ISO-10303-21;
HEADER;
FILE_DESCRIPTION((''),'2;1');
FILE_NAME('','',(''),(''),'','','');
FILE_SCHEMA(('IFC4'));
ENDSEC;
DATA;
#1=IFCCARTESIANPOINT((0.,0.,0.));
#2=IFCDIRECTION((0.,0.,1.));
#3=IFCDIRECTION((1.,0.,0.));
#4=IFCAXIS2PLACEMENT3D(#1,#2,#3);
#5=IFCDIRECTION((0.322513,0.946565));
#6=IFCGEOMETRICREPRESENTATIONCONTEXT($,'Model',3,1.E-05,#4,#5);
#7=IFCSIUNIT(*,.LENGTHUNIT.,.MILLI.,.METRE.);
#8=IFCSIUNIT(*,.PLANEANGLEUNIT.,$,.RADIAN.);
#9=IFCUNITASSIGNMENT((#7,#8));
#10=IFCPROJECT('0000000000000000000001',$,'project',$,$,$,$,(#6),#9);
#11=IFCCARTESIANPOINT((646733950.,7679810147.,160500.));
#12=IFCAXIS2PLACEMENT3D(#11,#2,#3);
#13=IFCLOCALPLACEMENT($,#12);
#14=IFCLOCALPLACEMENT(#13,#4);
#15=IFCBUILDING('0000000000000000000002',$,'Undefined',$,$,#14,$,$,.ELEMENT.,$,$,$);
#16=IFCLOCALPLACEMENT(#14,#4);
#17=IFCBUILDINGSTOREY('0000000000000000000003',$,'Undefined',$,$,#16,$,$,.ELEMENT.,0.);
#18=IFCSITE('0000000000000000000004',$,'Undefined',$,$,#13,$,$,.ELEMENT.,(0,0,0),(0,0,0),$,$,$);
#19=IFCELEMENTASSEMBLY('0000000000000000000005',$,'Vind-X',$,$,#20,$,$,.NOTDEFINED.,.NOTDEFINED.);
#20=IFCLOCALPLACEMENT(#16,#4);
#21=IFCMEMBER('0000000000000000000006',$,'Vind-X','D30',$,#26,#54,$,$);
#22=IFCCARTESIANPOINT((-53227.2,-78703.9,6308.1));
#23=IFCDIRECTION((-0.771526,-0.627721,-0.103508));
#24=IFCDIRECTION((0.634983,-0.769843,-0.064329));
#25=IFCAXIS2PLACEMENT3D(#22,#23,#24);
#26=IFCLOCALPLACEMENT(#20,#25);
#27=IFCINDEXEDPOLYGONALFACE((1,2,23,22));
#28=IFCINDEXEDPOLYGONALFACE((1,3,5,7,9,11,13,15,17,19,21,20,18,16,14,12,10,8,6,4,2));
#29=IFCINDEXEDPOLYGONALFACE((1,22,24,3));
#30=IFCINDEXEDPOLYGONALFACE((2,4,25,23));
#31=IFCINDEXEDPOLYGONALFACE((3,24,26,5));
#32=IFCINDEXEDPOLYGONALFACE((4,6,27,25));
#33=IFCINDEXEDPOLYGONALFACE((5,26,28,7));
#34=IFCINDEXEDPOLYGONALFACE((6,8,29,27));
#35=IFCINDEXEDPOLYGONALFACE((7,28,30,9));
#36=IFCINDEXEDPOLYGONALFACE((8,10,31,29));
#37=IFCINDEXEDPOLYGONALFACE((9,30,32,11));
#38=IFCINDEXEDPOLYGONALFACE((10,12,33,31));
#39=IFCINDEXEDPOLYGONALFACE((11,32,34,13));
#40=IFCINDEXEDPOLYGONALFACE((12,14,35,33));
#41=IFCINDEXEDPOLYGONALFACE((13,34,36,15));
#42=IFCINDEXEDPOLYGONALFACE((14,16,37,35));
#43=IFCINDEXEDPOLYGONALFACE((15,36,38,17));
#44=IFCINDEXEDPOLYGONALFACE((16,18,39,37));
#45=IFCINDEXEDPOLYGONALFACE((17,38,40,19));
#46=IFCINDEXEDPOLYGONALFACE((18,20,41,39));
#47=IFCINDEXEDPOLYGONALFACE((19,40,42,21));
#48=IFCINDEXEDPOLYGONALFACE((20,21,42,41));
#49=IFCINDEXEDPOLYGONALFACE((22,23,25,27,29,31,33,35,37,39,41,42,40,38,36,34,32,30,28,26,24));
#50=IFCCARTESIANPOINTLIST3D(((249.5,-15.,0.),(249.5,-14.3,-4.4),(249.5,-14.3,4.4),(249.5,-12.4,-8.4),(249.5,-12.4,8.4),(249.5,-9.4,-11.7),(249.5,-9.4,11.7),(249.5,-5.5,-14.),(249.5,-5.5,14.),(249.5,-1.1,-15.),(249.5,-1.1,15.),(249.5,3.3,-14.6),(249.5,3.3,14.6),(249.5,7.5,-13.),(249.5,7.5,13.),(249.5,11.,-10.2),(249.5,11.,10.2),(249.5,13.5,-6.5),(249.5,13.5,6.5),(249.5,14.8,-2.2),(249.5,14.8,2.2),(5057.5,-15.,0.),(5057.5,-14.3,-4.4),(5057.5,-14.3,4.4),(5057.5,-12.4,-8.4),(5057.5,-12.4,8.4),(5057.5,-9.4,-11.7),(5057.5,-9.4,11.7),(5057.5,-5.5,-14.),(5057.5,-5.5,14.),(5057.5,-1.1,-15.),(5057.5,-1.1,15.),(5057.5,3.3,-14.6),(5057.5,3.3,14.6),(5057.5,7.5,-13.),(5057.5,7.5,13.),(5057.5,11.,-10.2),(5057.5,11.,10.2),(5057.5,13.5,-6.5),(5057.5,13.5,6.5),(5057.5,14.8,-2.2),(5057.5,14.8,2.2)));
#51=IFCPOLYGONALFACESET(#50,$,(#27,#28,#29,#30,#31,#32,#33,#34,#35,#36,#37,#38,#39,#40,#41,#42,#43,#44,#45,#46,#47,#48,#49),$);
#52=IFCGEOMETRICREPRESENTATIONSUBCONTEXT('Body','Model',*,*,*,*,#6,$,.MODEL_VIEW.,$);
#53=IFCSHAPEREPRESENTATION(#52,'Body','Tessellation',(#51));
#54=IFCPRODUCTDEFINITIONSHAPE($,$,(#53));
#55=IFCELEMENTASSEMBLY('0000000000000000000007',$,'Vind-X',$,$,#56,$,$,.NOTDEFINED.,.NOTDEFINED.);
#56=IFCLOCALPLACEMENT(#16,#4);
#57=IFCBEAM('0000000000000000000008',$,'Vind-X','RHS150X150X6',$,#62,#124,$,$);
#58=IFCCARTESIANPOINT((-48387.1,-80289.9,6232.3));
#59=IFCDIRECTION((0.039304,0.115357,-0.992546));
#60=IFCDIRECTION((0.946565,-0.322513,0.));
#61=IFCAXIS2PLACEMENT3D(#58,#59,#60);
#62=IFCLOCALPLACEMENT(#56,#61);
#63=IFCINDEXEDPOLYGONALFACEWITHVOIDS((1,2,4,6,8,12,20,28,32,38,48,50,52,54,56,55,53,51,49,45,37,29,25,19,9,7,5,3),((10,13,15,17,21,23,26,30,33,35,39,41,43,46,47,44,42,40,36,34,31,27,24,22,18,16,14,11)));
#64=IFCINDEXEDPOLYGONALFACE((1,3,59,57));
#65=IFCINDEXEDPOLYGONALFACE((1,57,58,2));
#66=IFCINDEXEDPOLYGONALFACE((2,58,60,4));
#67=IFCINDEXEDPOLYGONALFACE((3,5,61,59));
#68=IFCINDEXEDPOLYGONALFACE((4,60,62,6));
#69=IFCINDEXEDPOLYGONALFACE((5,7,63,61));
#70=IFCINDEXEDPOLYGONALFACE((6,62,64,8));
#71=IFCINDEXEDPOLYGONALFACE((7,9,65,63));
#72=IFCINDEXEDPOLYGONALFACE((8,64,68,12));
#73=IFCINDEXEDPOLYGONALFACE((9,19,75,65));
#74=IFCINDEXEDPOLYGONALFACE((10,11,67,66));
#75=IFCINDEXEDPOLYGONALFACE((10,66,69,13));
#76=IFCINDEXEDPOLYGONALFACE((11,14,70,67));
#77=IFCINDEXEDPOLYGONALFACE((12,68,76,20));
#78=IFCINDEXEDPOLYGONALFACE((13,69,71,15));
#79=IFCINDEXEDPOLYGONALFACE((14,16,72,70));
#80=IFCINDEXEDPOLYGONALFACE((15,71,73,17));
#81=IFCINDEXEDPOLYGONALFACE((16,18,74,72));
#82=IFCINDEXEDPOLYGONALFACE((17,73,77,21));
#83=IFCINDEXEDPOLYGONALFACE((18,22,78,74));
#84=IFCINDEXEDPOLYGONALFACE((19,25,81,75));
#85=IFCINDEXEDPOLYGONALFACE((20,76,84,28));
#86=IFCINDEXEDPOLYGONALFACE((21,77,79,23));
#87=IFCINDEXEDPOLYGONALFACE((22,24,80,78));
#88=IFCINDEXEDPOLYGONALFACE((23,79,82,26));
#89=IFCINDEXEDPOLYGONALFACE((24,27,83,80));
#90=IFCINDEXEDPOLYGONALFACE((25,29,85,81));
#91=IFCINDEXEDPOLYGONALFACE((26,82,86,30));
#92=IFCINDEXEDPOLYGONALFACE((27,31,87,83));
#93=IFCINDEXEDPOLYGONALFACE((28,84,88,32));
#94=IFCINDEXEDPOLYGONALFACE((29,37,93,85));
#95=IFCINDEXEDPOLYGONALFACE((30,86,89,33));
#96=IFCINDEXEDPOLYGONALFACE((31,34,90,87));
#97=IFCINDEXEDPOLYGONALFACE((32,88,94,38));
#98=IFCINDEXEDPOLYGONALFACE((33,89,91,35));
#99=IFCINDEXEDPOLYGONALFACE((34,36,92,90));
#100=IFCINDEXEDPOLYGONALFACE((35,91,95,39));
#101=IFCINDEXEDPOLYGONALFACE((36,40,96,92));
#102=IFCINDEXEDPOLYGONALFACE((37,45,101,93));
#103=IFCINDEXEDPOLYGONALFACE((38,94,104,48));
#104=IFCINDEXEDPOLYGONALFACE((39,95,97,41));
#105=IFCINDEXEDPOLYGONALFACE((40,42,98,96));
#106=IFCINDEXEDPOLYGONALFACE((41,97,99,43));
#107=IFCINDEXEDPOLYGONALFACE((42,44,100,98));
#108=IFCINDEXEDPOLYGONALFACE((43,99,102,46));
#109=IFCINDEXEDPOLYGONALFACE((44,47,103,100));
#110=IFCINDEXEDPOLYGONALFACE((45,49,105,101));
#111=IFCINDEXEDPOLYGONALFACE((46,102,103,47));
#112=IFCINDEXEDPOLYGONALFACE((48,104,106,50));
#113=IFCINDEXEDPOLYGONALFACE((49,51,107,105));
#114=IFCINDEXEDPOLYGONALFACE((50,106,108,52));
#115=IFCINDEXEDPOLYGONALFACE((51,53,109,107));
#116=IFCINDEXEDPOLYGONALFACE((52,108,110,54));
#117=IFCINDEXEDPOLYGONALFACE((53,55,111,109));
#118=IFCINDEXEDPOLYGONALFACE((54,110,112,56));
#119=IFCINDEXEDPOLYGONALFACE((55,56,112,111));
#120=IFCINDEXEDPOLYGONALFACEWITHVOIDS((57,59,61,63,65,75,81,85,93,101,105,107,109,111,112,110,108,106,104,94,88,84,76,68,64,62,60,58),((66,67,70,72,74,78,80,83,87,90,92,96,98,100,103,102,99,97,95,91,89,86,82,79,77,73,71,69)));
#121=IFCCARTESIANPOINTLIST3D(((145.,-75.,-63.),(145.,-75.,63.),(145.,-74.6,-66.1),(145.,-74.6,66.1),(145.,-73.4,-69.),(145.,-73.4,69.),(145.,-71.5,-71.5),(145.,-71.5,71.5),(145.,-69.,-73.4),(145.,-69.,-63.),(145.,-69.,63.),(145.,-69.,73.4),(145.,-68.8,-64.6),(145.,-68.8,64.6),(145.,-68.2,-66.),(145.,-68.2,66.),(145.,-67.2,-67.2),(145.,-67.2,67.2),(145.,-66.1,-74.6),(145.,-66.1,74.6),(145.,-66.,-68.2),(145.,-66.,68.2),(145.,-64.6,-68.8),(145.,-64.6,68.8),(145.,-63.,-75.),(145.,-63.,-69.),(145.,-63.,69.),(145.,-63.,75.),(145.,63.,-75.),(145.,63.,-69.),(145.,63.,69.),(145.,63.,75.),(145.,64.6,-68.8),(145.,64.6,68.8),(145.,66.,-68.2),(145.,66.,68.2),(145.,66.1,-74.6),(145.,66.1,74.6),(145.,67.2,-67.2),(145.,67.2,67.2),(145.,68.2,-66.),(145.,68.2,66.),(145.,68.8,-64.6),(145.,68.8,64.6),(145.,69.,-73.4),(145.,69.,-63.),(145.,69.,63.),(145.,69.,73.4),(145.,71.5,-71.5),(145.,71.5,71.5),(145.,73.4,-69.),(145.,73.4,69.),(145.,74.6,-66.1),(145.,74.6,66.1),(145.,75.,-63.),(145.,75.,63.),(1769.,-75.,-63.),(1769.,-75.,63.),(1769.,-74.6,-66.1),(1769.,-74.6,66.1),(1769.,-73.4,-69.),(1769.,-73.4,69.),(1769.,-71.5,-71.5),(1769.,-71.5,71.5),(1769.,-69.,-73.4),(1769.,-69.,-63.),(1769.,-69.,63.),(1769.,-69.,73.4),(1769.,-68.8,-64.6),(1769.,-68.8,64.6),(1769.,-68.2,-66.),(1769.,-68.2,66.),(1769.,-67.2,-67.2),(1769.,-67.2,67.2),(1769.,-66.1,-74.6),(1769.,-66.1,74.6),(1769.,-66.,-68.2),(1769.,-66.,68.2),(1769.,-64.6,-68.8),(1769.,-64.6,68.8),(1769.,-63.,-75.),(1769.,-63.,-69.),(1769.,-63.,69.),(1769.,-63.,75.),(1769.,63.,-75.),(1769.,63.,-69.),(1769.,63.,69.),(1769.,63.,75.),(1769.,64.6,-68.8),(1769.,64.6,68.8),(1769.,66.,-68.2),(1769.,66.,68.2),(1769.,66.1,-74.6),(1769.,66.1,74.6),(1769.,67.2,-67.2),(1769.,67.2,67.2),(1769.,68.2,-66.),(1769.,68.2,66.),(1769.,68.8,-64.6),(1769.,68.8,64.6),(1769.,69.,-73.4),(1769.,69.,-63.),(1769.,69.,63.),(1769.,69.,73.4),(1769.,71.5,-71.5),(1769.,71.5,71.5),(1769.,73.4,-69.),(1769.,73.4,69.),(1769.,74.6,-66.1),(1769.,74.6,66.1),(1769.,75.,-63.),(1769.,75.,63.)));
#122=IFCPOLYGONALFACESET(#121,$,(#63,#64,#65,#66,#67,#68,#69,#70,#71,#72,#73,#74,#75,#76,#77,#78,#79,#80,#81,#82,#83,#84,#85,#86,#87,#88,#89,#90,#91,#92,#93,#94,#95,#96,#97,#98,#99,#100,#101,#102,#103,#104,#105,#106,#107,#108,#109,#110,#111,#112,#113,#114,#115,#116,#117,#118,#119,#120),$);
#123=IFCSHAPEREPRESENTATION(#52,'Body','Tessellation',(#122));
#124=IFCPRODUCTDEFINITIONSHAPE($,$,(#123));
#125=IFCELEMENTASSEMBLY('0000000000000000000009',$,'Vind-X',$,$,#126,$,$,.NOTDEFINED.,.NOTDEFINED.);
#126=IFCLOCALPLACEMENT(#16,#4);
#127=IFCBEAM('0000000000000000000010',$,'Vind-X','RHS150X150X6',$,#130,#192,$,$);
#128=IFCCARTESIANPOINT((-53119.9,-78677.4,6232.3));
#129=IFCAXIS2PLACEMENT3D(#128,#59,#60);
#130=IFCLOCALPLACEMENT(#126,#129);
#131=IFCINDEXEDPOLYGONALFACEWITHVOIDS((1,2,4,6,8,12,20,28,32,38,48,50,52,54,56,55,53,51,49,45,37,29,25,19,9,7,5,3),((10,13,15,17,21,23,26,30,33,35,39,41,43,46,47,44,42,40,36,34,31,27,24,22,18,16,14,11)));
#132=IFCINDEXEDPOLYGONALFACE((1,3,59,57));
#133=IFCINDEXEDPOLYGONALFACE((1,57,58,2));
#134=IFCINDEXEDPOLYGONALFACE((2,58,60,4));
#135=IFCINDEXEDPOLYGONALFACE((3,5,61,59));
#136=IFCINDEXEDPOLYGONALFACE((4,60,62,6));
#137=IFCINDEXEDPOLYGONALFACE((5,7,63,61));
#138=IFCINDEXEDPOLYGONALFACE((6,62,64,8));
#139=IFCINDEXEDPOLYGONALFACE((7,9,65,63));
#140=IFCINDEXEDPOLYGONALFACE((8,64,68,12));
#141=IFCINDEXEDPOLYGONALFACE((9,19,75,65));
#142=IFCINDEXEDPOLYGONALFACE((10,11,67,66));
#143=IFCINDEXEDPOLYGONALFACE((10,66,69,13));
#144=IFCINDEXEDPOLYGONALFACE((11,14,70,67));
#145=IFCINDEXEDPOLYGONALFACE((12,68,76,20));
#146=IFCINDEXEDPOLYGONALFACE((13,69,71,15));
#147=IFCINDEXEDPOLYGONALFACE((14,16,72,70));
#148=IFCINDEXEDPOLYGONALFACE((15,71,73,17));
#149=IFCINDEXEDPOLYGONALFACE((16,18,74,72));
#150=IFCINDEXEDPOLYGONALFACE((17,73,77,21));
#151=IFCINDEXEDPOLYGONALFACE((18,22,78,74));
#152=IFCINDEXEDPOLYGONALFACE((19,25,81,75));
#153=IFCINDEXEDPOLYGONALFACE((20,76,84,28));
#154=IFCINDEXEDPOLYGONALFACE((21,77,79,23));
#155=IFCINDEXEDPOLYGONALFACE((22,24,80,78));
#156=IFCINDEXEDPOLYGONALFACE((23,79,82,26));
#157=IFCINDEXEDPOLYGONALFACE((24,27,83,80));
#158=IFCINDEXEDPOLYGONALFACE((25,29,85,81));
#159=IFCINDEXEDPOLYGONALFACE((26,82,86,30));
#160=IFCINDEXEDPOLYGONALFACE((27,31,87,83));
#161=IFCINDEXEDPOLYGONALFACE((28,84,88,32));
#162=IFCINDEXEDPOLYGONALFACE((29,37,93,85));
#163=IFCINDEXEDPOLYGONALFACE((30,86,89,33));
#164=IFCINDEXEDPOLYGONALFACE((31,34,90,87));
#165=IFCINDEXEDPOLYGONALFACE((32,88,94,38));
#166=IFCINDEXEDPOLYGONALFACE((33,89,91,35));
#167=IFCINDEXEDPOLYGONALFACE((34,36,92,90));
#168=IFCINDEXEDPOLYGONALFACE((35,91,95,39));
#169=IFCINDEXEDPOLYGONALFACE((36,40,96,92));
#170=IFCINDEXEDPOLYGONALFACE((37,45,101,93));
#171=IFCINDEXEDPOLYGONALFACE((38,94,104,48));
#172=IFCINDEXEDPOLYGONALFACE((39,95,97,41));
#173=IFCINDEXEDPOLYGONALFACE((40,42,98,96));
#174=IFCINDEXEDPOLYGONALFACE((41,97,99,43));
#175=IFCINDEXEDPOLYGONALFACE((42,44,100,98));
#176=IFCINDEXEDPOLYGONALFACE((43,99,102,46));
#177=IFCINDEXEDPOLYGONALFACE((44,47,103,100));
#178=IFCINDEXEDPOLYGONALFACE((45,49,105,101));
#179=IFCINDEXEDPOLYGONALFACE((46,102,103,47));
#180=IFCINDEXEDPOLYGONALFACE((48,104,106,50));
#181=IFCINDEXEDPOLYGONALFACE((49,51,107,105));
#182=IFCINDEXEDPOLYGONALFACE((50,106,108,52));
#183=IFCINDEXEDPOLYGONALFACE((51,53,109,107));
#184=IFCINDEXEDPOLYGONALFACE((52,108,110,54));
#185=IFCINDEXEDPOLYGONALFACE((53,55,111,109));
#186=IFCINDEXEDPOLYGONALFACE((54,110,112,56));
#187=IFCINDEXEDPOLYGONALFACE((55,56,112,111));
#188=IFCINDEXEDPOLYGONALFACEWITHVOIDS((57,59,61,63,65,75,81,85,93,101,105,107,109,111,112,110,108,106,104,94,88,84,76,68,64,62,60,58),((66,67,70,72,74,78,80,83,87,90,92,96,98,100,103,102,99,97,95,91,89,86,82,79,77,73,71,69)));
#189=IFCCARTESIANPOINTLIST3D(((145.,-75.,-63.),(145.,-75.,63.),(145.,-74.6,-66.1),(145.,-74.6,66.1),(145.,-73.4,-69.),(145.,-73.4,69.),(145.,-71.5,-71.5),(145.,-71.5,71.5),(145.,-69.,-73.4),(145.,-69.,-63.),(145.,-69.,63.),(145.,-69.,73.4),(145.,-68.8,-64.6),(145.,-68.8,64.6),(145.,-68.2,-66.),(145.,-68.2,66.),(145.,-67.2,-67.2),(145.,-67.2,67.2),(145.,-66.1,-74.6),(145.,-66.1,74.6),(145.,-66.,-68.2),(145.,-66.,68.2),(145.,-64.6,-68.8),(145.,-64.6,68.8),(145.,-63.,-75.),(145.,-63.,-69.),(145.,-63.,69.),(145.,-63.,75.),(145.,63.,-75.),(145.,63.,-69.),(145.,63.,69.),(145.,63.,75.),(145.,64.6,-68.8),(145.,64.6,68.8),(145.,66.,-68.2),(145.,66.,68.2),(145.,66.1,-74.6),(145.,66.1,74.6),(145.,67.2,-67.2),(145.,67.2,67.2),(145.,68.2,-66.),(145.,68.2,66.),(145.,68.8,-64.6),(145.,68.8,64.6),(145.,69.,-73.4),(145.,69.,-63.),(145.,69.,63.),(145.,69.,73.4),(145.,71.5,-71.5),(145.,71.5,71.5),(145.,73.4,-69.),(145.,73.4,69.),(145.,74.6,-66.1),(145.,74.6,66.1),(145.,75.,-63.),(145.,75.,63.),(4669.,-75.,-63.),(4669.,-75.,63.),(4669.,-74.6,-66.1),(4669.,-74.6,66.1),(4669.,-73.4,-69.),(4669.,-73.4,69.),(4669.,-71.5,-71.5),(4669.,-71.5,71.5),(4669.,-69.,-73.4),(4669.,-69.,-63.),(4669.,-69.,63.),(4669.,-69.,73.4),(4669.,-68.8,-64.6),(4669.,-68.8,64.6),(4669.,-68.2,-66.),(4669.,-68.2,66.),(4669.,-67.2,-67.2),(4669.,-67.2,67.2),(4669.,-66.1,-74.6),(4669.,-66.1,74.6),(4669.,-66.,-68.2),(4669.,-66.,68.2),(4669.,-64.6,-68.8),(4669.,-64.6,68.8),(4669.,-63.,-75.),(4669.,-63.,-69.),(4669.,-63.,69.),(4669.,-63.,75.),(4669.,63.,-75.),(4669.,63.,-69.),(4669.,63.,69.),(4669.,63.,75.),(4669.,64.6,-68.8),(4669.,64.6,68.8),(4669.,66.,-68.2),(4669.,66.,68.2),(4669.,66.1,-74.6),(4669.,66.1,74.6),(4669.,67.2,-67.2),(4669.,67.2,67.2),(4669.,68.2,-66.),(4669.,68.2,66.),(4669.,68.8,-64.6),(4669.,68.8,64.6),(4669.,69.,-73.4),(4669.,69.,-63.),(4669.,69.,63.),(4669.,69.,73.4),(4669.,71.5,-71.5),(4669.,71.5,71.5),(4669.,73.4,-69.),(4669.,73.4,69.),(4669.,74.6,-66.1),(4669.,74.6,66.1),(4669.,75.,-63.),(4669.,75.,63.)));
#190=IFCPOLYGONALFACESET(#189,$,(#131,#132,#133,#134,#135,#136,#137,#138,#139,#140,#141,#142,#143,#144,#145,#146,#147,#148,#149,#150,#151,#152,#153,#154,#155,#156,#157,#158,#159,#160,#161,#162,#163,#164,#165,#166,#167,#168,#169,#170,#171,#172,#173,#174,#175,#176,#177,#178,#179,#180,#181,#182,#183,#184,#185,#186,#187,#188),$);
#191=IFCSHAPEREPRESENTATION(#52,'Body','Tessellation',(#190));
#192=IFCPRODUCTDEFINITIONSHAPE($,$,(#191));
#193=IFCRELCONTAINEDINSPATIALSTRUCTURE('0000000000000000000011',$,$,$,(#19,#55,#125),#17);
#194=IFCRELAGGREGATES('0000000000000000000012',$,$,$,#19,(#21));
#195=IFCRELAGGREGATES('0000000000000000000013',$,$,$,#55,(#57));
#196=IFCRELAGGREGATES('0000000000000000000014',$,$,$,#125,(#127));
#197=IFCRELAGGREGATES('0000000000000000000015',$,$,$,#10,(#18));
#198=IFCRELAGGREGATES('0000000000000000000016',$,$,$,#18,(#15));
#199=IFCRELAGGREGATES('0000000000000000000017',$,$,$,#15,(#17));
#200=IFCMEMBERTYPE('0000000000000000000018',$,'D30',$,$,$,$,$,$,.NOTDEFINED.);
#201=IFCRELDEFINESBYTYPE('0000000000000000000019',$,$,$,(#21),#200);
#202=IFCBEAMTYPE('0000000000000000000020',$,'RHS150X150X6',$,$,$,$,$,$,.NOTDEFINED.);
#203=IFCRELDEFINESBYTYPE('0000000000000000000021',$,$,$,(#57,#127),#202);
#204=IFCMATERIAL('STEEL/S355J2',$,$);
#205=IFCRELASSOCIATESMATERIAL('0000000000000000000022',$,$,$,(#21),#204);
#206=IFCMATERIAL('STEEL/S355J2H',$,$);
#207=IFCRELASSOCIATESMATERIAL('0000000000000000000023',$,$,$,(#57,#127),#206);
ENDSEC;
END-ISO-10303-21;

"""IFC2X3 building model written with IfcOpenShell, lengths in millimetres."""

from ifc_helpers import new_model, si_unit, direction, frame, origin_with_axes, origin_2d_with_axis, place, context, subcontext, project, spatial, hollow_rectangle, circle, extrude, clip, halfspace, material, type_object, element, aggregate, save


model = new_model("IFC2X3")

# Units and contexts
model_context = context("Model", 3, precision=1e-05, world=origin_with_axes(), true_north=direction((0.322513, 0.946565)))
body_context = subcontext(model_context, "Body", "Model", "MODEL_VIEW")
ifc_project = project(units=[si_unit("LENGTHUNIT", "METRE", prefix="MILLI"), si_unit("PLANEANGLEUNIT", "RADIAN")], contexts=[model_context])

# Site, building, storey
site_placement = place(None, frame((646733950.0, 7679810147.0, 160500.0), z_axis=(0.0, 0.0, 1.0), x_axis=(1.0, 0.0, 0.0)))
site = spatial("IfcSite", under=ifc_project, at=site_placement, Name="Undefined", CompositionType="ELEMENT", RefLatitude=(0, 0, 0), RefLongitude=(0, 0, 0))
building_placement = place(site_placement, origin_with_axes())
building = spatial("IfcBuilding", under=site, at=building_placement, Name="Undefined", CompositionType="ELEMENT")
storey_placement = place(building_placement, origin_with_axes())
storey = spatial("IfcBuildingStorey", under=building, at=storey_placement, Name="Undefined", CompositionType="ELEMENT", Elevation=0.0)

# Shared definitions
ifc_material_1 = material(Name="STEEL/S355J2")

# Shared definitions
member_type = type_object("IfcMemberType", Name="D30", PredefinedType="NOTDEFINED")

# Element assembly, member
assembly_1_placement = place(storey_placement, origin_with_axes())
assembly_1 = element("IfcElementAssembly", 1, at=assembly_1_placement, inside=storey, Name="Vind-X", AssemblyPlace="NOTDEFINED", PredefinedType="NOTDEFINED")
member_1_placement = place(assembly_1_placement, frame((-53227.2, -78703.9, 6308.1), z_axis=(-0.771526, -0.627721, -0.103508), x_axis=(0.634983, -0.769843, -0.064329)))
member_1 = element("IfcMember", 2, at=member_1_placement, type_object=member_type, material=ifc_material_1, Name="Vind-X", Description="D30", context=body_context, shape_type="Clipping", body=[
    clip(extrude(circle(Radius=15.0, at=origin_2d_with_axis()), frame((5057.5, 0.0, 0.0), z_axis=(-1.0, 0.0, 0.0), x_axis=(0.0, -1.0, 0.0)), (0.0, 0.0, 1.0), 5057.5), halfspace(frame((249.5, -22.5, 0.0), z_axis=(1.0, 0.0, 0.0), x_axis=(0.0, 0.0, 1.0)), True)),
])

# Element assemblies, beams
assembly_2_placement = place(storey_placement, origin_with_axes())
assembly_2 = element("IfcElementAssembly", 3, at=assembly_2_placement, inside=storey, Name="Vind-X", AssemblyPlace="NOTDEFINED", PredefinedType="NOTDEFINED")
ifc_material_2 = material(Name="STEEL/S355J2H")
beam_type_1 = type_object("IfcBeamType", Name="RHS150X150X6", PredefinedType="NOTDEFINED")
beam_1_placement = place(assembly_2_placement, frame((-48387.1, -80289.9, 6232.3), z_axis=(0.039304, 0.115357, -0.992546), x_axis=(0.946565, -0.322513, 0.0)))
beam_1 = element("IfcBeam", 4, at=beam_1_placement, type_object=beam_type_1, material=ifc_material_2, Name="Vind-X", Description="RHS150X150X6", context=body_context, shape_type="Clipping", body=[
    clip(clip(extrude(hollow_rectangle(XDim=150.0, YDim=150.0, WallThickness=6.0, InnerFilletRadius=6.0, OuterFilletRadius=12.0, at=origin_2d_with_axis()), frame((1914.0, 0.0, 0.0), z_axis=(-1.0, 0.0, 0.0), x_axis=(0.0, -1.0, 0.0)), (0.0, 0.0, 1.0), 1914.0), halfspace(frame((1769.0, 0.0, 0.0), z_axis=(-1.0, 0.0, 0.0), x_axis=(0.0, 1.0, 0.0)), True)), halfspace(frame((145.0, 0.0, 0.0), z_axis=(1.0, 0.0, 0.0), x_axis=(0.0, -1.0, 0.0)), True)),
])
assembly_3_placement = place(storey_placement, origin_with_axes())
assembly_3 = element("IfcElementAssembly", 5, at=assembly_3_placement, inside=storey, Name="Vind-X", AssemblyPlace="NOTDEFINED", PredefinedType="NOTDEFINED")
beam_2_placement = place(assembly_3_placement, frame((-53119.9, -78677.4, 6232.3), z_axis=(0.039304, 0.115357, -0.992546), x_axis=(0.946565, -0.322513, 0.0)))
beam_2 = element("IfcBeam", 6, at=beam_2_placement, type_object=beam_type_1, material=ifc_material_2, Name="Vind-X", Description="RHS150X150X6", context=body_context, shape_type="Clipping", body=[
    clip(clip(extrude(hollow_rectangle(XDim=150.0, YDim=150.0, WallThickness=6.0, InnerFilletRadius=6.0, OuterFilletRadius=12.0, at=origin_2d_with_axis()), frame((4814.0, 0.0, 0.0), z_axis=(-1.0, 0.0, 0.0), x_axis=(0.0, -1.0, 0.0)), (0.0, 0.0, 1.0), 4814.0), halfspace(frame((4669.0, 0.0, 0.0), z_axis=(-1.0, 0.0, 0.0), x_axis=(0.0, 1.0, 0.0)), True)), halfspace(frame((145.0, 0.0, 0.0), z_axis=(1.0, 0.0, 0.0), x_axis=(0.0, -1.0, 0.0)), True)),
])

aggregate(assembly_1, [member_1])
aggregate(assembly_2, [beam_1])
aggregate(assembly_3, [beam_2])

save(model, "model.ifc")
